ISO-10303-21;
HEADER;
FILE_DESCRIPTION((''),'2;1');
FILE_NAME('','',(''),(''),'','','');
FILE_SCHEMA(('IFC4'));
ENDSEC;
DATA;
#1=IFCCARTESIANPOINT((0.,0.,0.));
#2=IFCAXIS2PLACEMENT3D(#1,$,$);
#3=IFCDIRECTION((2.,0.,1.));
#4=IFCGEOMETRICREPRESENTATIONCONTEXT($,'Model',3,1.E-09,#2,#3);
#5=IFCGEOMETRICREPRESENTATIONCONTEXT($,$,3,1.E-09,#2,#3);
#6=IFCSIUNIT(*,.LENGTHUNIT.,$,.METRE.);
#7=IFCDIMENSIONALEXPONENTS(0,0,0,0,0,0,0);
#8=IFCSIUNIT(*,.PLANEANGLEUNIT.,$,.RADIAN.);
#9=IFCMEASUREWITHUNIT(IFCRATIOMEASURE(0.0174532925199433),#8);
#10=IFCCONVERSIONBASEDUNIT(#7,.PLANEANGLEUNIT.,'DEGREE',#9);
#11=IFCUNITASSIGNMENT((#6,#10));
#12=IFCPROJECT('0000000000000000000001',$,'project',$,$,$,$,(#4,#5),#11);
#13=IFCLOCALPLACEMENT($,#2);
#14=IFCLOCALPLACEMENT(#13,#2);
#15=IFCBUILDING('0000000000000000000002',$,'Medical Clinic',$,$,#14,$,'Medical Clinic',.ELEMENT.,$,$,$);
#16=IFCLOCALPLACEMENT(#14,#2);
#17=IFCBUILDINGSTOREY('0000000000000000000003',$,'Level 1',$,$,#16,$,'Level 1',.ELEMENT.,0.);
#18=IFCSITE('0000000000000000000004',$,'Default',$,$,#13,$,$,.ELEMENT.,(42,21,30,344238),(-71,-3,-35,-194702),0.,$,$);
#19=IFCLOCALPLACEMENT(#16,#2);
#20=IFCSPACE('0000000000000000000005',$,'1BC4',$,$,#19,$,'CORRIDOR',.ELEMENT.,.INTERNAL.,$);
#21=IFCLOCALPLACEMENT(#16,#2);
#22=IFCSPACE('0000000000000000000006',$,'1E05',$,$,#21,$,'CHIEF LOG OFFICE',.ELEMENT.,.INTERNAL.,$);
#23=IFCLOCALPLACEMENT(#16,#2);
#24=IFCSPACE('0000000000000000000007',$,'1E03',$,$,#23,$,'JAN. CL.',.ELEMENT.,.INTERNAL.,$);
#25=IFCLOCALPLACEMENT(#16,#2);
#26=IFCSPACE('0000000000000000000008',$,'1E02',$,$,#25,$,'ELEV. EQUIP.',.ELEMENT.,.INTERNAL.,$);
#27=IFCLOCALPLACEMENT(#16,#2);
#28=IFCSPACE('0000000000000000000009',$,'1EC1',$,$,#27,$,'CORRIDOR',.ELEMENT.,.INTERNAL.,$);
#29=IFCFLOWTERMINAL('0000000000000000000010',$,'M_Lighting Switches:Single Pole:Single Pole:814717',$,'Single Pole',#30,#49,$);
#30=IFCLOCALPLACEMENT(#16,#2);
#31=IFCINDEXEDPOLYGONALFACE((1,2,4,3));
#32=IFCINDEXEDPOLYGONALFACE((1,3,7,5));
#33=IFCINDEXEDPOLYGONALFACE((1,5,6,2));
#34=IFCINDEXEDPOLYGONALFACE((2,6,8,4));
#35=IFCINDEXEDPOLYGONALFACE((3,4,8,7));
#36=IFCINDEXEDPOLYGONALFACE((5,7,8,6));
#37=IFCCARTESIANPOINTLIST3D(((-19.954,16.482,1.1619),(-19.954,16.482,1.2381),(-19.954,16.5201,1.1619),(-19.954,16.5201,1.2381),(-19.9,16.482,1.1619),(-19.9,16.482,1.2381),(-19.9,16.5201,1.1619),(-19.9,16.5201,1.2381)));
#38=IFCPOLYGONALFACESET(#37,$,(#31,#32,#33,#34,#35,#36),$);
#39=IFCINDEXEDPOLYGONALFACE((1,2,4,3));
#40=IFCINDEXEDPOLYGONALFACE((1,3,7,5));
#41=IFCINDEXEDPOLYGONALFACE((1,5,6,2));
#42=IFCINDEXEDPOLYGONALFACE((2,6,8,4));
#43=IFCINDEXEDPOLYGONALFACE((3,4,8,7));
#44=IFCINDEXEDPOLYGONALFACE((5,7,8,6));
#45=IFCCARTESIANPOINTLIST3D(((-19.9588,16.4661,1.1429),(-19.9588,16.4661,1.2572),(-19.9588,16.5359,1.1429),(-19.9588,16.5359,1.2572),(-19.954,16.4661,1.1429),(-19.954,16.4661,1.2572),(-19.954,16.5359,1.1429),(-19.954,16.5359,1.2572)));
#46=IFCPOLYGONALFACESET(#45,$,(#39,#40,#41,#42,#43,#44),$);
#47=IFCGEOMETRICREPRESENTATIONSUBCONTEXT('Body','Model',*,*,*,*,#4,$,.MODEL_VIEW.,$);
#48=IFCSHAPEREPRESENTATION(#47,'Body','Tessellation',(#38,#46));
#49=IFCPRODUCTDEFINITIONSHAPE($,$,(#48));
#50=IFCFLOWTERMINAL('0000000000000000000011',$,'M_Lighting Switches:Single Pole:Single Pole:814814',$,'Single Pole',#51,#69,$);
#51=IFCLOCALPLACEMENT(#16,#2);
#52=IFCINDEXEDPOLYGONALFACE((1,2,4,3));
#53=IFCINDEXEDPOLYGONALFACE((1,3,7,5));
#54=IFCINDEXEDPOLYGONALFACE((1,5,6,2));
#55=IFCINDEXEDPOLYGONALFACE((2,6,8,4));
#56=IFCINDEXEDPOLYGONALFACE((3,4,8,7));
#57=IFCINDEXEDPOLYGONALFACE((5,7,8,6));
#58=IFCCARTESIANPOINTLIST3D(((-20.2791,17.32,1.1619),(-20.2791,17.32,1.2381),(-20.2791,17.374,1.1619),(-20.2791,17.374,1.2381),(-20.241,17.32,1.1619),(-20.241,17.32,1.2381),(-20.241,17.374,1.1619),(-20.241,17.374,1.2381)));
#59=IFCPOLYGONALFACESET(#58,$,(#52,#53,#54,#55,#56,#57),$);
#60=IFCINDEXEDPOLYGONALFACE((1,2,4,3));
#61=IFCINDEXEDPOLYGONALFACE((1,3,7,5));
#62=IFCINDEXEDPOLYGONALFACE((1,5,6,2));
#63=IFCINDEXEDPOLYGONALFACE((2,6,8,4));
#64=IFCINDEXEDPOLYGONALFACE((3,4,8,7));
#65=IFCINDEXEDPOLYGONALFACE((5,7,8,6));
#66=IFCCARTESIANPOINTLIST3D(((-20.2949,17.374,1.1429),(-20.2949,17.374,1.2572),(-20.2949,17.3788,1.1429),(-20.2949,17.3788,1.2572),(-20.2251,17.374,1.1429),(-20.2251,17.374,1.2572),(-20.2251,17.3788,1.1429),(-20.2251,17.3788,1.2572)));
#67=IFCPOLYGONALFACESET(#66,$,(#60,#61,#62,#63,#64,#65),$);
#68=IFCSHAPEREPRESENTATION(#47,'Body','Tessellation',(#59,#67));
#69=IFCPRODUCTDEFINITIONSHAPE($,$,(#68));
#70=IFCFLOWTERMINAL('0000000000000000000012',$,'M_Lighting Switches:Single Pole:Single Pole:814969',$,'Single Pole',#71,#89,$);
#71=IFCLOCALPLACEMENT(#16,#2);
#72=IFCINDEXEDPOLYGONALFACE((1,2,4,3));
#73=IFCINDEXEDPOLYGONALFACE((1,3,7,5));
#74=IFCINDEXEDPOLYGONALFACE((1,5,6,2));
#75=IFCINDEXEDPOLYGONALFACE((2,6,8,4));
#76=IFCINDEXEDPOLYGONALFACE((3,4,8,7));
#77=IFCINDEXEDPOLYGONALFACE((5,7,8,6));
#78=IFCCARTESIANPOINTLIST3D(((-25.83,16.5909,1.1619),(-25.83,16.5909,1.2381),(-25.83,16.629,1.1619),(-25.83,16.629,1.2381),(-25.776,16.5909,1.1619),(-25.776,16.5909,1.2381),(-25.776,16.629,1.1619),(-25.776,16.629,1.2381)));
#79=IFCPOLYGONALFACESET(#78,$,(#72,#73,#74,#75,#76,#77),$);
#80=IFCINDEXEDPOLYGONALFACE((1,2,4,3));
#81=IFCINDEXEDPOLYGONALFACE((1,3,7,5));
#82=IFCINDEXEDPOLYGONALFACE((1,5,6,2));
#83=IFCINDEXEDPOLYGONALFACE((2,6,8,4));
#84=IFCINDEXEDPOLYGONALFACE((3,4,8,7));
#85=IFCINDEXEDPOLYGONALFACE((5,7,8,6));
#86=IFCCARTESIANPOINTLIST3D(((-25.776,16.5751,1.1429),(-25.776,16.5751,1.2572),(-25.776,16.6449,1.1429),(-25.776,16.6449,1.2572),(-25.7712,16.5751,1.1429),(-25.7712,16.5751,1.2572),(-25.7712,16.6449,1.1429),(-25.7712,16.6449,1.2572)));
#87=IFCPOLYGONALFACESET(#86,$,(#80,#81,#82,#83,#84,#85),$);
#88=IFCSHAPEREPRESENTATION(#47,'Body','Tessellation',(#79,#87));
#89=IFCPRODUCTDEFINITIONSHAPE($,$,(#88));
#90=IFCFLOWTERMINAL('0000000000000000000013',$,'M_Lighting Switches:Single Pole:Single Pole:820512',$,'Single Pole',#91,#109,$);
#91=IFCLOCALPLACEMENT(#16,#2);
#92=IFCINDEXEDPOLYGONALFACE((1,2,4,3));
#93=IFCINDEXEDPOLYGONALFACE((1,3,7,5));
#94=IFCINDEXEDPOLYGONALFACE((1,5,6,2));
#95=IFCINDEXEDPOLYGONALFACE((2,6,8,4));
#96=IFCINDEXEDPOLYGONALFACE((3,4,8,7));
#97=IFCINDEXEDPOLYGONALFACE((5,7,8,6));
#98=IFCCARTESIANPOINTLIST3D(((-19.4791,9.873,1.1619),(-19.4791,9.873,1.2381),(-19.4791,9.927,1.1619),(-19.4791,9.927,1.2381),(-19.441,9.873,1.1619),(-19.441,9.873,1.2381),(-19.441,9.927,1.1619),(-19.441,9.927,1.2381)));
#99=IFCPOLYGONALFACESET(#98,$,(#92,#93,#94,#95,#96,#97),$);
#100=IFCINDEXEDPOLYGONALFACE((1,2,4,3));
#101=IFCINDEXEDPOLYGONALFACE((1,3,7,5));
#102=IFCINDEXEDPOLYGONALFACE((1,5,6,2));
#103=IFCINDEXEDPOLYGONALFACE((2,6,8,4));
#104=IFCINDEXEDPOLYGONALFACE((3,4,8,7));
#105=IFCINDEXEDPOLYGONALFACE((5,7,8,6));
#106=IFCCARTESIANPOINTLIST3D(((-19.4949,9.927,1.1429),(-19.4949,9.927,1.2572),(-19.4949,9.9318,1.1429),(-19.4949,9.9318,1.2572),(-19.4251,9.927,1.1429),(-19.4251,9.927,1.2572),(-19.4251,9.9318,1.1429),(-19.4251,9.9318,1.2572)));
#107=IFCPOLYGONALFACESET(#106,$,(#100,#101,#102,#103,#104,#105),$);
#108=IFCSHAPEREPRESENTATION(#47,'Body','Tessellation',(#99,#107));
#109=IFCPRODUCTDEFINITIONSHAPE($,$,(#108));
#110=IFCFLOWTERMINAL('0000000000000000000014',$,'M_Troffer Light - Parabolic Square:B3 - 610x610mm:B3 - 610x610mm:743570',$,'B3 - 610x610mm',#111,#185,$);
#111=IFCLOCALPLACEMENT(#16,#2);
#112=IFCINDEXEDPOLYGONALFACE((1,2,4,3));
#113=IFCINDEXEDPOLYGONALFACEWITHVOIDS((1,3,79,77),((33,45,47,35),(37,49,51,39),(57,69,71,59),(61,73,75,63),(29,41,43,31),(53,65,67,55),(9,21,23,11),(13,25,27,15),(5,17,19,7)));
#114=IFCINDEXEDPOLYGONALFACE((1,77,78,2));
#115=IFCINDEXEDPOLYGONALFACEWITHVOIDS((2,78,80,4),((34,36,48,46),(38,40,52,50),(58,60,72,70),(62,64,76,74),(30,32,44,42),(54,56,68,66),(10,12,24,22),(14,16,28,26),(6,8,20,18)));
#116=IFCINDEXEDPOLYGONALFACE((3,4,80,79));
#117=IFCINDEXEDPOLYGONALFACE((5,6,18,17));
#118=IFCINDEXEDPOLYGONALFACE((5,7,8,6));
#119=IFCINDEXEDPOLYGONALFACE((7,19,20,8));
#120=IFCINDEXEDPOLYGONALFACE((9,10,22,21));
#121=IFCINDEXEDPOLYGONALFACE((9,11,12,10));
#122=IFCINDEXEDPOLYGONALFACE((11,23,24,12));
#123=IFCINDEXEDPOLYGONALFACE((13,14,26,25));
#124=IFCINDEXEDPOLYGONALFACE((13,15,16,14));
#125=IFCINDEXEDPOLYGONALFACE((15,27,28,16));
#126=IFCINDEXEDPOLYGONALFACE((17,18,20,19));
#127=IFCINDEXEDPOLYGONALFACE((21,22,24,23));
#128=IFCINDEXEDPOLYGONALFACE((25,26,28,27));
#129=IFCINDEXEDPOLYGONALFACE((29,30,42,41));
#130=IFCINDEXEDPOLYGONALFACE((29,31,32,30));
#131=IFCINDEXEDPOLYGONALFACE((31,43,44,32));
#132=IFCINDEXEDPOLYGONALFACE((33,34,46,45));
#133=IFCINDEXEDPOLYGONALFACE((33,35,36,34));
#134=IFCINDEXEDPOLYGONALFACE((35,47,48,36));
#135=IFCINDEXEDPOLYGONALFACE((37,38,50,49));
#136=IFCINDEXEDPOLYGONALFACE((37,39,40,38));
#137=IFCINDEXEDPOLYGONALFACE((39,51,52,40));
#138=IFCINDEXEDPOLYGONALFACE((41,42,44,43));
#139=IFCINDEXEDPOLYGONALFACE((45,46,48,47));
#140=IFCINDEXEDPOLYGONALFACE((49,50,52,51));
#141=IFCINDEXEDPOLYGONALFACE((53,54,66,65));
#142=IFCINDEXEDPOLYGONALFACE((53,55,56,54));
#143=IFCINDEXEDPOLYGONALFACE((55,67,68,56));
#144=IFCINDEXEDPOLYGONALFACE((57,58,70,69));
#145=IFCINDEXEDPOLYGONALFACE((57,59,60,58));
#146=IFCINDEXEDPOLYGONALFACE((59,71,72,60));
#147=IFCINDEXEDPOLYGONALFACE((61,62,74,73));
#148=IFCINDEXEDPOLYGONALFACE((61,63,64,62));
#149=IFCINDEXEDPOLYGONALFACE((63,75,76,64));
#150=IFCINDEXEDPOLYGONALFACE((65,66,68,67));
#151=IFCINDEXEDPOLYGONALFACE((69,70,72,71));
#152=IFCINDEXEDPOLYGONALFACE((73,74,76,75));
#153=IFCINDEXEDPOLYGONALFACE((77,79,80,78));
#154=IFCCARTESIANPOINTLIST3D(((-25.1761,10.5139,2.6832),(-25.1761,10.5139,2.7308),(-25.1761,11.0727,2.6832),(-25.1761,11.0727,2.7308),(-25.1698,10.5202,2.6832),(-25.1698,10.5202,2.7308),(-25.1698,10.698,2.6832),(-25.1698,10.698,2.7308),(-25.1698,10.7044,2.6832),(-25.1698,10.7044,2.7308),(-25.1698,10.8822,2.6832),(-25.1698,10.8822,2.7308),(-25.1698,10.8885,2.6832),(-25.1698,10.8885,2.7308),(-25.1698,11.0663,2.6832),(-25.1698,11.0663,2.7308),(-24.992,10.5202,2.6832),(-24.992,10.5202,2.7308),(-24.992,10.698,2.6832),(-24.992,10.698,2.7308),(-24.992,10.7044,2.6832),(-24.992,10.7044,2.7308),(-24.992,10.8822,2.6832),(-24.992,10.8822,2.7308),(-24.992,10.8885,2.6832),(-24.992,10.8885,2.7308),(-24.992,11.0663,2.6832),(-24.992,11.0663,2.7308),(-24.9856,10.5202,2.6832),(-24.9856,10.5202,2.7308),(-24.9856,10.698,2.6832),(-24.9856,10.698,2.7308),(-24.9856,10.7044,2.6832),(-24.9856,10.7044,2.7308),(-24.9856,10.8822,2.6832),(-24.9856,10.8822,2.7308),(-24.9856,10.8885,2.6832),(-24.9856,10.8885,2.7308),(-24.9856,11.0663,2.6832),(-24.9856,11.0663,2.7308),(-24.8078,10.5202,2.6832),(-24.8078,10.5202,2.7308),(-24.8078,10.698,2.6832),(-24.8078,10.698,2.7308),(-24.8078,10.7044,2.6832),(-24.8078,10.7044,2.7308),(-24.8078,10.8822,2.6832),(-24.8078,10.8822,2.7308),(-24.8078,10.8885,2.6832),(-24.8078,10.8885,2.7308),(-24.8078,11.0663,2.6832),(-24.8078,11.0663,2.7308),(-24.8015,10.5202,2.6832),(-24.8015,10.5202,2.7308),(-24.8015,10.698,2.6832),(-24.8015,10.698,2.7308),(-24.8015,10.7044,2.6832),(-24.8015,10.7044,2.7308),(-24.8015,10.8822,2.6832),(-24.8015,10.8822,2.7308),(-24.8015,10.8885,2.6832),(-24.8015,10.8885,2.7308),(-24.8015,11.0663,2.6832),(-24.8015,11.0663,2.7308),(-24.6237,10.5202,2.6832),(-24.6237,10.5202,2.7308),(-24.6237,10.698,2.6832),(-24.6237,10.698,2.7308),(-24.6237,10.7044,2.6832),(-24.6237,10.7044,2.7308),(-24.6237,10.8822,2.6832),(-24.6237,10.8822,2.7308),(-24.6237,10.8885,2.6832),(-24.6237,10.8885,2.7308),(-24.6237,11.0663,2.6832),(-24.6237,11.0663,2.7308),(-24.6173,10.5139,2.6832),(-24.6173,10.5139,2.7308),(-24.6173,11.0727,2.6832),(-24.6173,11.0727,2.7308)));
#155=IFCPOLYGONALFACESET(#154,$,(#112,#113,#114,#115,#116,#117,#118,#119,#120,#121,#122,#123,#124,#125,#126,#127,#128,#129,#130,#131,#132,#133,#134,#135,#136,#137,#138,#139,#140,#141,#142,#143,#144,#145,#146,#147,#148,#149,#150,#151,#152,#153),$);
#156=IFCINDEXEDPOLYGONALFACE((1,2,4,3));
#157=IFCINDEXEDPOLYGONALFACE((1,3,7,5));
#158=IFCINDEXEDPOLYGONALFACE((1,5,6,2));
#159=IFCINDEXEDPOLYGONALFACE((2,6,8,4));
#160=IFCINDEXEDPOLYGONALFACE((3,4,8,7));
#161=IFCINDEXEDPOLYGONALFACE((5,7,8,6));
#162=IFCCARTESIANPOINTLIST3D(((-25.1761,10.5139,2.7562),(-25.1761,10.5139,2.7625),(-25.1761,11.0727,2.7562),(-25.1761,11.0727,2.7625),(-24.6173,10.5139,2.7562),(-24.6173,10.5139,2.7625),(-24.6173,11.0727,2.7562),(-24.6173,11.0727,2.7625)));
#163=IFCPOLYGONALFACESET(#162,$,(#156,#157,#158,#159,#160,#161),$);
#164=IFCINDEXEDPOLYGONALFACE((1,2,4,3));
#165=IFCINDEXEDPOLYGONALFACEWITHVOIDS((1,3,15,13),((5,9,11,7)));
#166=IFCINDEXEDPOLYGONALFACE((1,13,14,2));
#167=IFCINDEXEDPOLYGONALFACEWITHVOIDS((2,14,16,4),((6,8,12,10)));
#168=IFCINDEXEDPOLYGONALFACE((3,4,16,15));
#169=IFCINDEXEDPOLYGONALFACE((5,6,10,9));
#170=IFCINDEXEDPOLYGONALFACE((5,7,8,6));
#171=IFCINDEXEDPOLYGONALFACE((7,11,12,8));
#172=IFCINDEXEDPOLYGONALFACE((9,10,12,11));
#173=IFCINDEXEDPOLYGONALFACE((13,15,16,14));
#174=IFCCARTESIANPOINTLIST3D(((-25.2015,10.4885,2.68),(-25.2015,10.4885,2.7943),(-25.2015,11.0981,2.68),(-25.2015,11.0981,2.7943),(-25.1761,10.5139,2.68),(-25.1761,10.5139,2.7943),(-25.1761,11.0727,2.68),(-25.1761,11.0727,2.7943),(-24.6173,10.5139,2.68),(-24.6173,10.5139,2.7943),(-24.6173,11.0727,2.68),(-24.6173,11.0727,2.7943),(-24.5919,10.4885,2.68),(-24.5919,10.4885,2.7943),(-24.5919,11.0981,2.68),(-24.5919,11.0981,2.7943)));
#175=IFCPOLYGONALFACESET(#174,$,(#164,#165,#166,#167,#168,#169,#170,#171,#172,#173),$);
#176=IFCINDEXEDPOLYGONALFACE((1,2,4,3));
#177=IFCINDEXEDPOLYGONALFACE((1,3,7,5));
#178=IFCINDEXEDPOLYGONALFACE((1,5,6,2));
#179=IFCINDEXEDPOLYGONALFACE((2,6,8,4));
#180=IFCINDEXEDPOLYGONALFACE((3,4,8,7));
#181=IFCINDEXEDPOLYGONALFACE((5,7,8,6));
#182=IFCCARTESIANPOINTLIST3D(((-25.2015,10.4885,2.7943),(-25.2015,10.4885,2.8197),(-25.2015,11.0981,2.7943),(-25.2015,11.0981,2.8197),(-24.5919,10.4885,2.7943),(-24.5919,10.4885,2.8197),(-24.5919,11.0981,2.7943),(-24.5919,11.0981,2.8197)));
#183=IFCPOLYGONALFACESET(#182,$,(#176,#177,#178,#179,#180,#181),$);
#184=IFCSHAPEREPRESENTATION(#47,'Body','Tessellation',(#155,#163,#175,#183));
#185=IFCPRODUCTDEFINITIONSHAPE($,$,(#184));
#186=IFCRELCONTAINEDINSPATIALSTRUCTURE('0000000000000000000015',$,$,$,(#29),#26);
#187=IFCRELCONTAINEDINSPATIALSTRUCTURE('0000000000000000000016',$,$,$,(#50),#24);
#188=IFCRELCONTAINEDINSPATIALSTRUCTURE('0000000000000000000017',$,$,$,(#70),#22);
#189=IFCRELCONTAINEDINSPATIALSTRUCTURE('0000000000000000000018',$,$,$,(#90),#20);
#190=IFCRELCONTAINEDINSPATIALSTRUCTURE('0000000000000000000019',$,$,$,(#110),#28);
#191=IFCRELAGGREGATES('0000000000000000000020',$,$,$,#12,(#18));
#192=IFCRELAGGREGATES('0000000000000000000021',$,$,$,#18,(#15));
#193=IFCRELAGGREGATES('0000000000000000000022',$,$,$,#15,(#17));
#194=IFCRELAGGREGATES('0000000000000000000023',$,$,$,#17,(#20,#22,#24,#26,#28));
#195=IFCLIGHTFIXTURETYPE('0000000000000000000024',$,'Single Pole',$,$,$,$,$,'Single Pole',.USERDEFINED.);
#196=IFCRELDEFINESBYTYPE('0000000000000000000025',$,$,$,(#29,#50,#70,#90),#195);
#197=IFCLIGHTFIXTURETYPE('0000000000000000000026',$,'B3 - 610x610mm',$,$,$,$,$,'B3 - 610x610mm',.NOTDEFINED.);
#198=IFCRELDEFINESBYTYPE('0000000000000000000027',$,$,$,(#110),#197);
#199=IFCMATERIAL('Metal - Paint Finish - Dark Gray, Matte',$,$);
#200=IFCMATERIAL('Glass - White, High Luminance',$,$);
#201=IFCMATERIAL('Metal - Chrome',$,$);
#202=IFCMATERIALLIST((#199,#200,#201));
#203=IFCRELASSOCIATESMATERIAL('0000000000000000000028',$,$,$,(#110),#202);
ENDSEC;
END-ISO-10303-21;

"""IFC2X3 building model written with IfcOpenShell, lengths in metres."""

from ifc_helpers import new_model, entity, si_unit, converted_unit, direction, frame, frame_2d, origin, origin_2d_with_axis, place, context, subcontext, project, spatial, polyline, rectangle, outline, extrude, source, transform, mapped, material, material_list, type_object, type_shapes, element, save


model = new_model("IFC2X3")

# Units and contexts
model_context = context("Model", 3, precision=1e-09, world=origin(), true_north=direction((2.0, 0.0, 1.0)))
context_of_model = context(None, 3, precision=1e-09, world=origin(), true_north=direction((2.0, 0.0, 1.0)))
body_context = subcontext(model_context, "Body", "Model", "MODEL_VIEW")
ifc_project = project(units=[si_unit("LENGTHUNIT", "METRE"), converted_unit("PLANEANGLEUNIT", "DEGREE", entity("IfcRatioMeasure", 0.0174532925199433), si_unit("PLANEANGLEUNIT", "RADIAN"), dimensions=[0, 0, 0, 0, 0, 0, 0])], contexts=[model_context, context_of_model])

# Site, building, storey
site_placement = place(None, origin())
site = spatial("IfcSite", under=ifc_project, at=site_placement, Name="Default", CompositionType="ELEMENT", RefLatitude=(42, 21, 30, 344238), RefLongitude=(-71, -3, -35, -194702), RefElevation=0.0)
building_placement = place(site_placement, origin())
building = spatial("IfcBuilding", under=site, at=building_placement, Name="Medical Clinic", LongName="Medical Clinic", CompositionType="ELEMENT")
storey_placement = place(building_placement, origin())
storey = spatial("IfcBuildingStorey", under=building, at=storey_placement, Name="Level 1", LongName="Level 1", CompositionType="ELEMENT", Elevation=0.0)

# Shared definitions
space_1_placement = place(storey_placement, origin())
space_1 = spatial("IfcSpace", under=storey, at=space_1_placement, Name="1BC4", LongName="CORRIDOR", CompositionType="ELEMENT", InteriorOrExteriorSpace="INTERNAL")

# Shared definitions
space_2_placement = place(storey_placement, origin())
space_2 = spatial("IfcSpace", under=storey, at=space_2_placement, Name="1E05", LongName="CHIEF LOG OFFICE", CompositionType="ELEMENT", InteriorOrExteriorSpace="INTERNAL")

# Shared definitions
space_3_placement = place(storey_placement, origin())
space_3 = spatial("IfcSpace", under=storey, at=space_3_placement, Name="1E03", LongName="JAN. CL.", CompositionType="ELEMENT", InteriorOrExteriorSpace="INTERNAL")

# Shared definitions
space_4_placement = place(storey_placement, origin())
space_4 = spatial("IfcSpace", under=storey, at=space_4_placement, Name="1E02", LongName="ELEV. EQUIP.", CompositionType="ELEMENT", InteriorOrExteriorSpace="INTERNAL")

# Flow terminals
light_fixture_type_1 = type_object("IfcLightFixtureType", Name="Single Pole", ElementType="Single Pole", PredefinedType="USERDEFINED")
shared_shape_1 = source(origin(), body_context, "Body", "SweptSolid", [
    extrude(rectangle(XDim=0.0381, YDim=0.0762, at=origin_2d_with_axis()), frame((0.0, 0.0, -0.054), z_axis=(0.0, 0.0, 1.0), x_axis=(-1.0, 0.0, 0.0)), (0.0, 0.0, 1.0), 0.054),
    extrude(rectangle(XDim=0.0698, YDim=0.1143, at=frame_2d((0.0, 0.0), x_axis=(1.0, 0.0))), frame((0.0, 0.0, 0.0), z_axis=(0.0, 0.0, 1.0), x_axis=(-1.0, 0.0, 0.0)), (0.0, 0.0, 1.0), 0.0048),
])
type_shapes(light_fixture_type_1, [shared_shape_1])
flow_terminal_1_placement = place(space_4_placement, frame((-19.954, 16.501, 1.2), z_axis=(-1.0, 0.0, 0.0), x_axis=(0.0, -1.0, 0.0)))
element("IfcFlowTerminal", 1, at=flow_terminal_1_placement, inside=space_4, type_object=light_fixture_type_1, Name="M_Lighting Switches:Single Pole:Single Pole:814717", ObjectType="Single Pole", context=body_context, shape_type="MappedRepresentation", body=[
    mapped(shared_shape_1, transform((0.0, 0.0, 0.0), scale=1.0)),
])
flow_terminal_2_placement = place(space_3_placement, frame((-20.26, 17.374, 1.2), z_axis=(0.0, 1.0, 0.0), x_axis=(-1.0, 0.0, 0.0)))
element("IfcFlowTerminal", 2, at=flow_terminal_2_placement, inside=space_3, type_object=light_fixture_type_1, Name="M_Lighting Switches:Single Pole:Single Pole:814814", ObjectType="Single Pole", context=body_context, shape_type="MappedRepresentation", body=[
    mapped(shared_shape_1, transform((0.0, 0.0, 0.0), scale=1.0)),
])
flow_terminal_3_placement = place(space_2_placement, frame((-25.776, 16.61, 1.2), z_axis=(1.0, 0.0, 0.0), x_axis=(0.0, 1.0, 0.0)))
element("IfcFlowTerminal", 3, at=flow_terminal_3_placement, inside=space_2, type_object=light_fixture_type_1, Name="M_Lighting Switches:Single Pole:Single Pole:814969", ObjectType="Single Pole", context=body_context, shape_type="MappedRepresentation", body=[
    mapped(shared_shape_1, transform((0.0, 0.0, 0.0), scale=1.0)),
])
flow_terminal_4_placement = place(space_1_placement, frame((-19.46, 9.927, 1.2), z_axis=(0.0, 1.0, 0.0), x_axis=(-1.0, 0.0, 0.0)))
element("IfcFlowTerminal", 4, at=flow_terminal_4_placement, inside=space_1, type_object=light_fixture_type_1, Name="M_Lighting Switches:Single Pole:Single Pole:820512", ObjectType="Single Pole", context=body_context, shape_type="MappedRepresentation", body=[
    mapped(shared_shape_1, transform((0.0, 0.0, 0.0), scale=1.0)),
])

# Shared definitions
space_5_placement = place(storey_placement, origin())
space_5 = spatial("IfcSpace", under=storey, at=space_5_placement, Name="1EC1", LongName="CORRIDOR", CompositionType="ELEMENT", InteriorOrExteriorSpace="INTERNAL")

# Flow terminal
ifc_material_1 = material(Name="Metal - Paint Finish - Dark Gray, Matte")
ifc_material_2 = material(Name="Glass - White, High Luminance")
ifc_material_3 = material(Name="Metal - Chrome")
ifc_material_list_1 = material_list([ifc_material_1, ifc_material_2, ifc_material_3])
light_fixture_type_2 = type_object("IfcLightFixtureType", Name="B3 - 610x610mm", ElementType="B3 - 610x610mm", PredefinedType="NOTDEFINED")
shared_shape_2 = source(origin(), body_context, "Body", "SweptSolid", [
    extrude(outline(polyline([(-0.2794, -0.2794), (0.2794, -0.2794), (0.2794, 0.2794), (-0.2794, 0.2794), (-0.2794, -0.2794)]), holes=[polyline([(-0.0952, 0.0953), (-0.273, 0.0953), (-0.273, 0.2731), (-0.0952, 0.2731), (-0.0952, 0.0953)]), polyline([(0.2731, 0.0953), (0.0953, 0.0953), (0.0953, 0.2731), (0.2731, 0.2731), (0.2731, 0.0953)]), polyline([(-0.0889, 0.2731), (0.0889, 0.2731), (0.0889, 0.0953), (-0.0889, 0.0953), (-0.0889, 0.2731)]), polyline([(0.2731, -0.273), (0.0953, -0.273), (0.0953, -0.0952), (0.2731, -0.0952), (0.2731, -0.273)]), polyline([(0.0889, -0.273), (-0.0889, -0.273), (-0.0889, -0.0952), (0.0889, -0.0952), (0.0889, -0.273)]), polyline([(-0.0952, -0.273), (-0.273, -0.273), (-0.273, -0.0952), (-0.0952, -0.0952), (-0.0952, -0.273)]), polyline([(-0.0952, -0.0889), (-0.273, -0.0889), (-0.273, 0.0889), (-0.0952, 0.0889), (-0.0952, -0.0889)]), polyline([(0.0889, -0.0889), (-0.0889, -0.0889), (-0.0889, 0.0889), (0.0889, 0.0889), (0.0889, -0.0889)]), polyline([(0.2731, -0.0889), (0.0953, -0.0889), (0.0953, 0.0889), (0.2731, 0.0889), (0.2731, -0.0889)])]), frame((0.0, -0.3048, -0.0508), z_axis=(0.0, 0.0, 1.0), x_axis=(-1.0, 0.0, 0.0)), (0.0, 0.0, 1.0), 0.0476),
    extrude(rectangle(XDim=0.5588, YDim=0.5588, at=origin_2d_with_axis()), frame((0.0, -0.3048, -0.0825), z_axis=(0.0, 0.0, 1.0), x_axis=(-1.0, 0.0, 0.0)), (0.0, 0.0, 1.0), 0.0064),
    extrude(outline(polyline([(-0.3048, -0.3048), (0.3048, -0.3048), (0.3048, 0.3048), (-0.3048, 0.3048), (-0.3048, -0.3048)]), holes=[polyline([(0.2794, 0.2794), (0.2794, -0.2794), (-0.2794, -0.2794), (-0.2794, 0.2794), (0.2794, 0.2794)])]), frame((0.0, -0.3048, -0.1143)), (0.0, 0.0, 1.0), 0.1143),
    extrude(rectangle(XDim=0.6096, YDim=0.6096, at=origin_2d_with_axis()), frame((0.0, -0.3048, -0.1397), z_axis=(0.0, 0.0, 1.0), x_axis=(-1.0, 0.0, 0.0)), (0.0, 0.0, 1.0), 0.0254),
])
type_shapes(light_fixture_type_2, [shared_shape_2])
flow_terminal_5_placement = place(space_5_placement, frame((-24.8967, 10.4885, 2.68), z_axis=(0.0, 0.0, -1.0), x_axis=(1.0, 0.0, 0.0)))
element("IfcFlowTerminal", 5, at=flow_terminal_5_placement, inside=space_5, type_object=light_fixture_type_2, material=ifc_material_list_1, Name="M_Troffer Light - Parabolic Square:B3 - 610x610mm:B3 - 610x610mm:743570", ObjectType="B3 - 610x610mm", context=body_context, shape_type="MappedRepresentation", body=[
    mapped(shared_shape_2, transform((0.0, 0.0, 0.0), scale=1.0)),
])

save(model, "model.ifc")
